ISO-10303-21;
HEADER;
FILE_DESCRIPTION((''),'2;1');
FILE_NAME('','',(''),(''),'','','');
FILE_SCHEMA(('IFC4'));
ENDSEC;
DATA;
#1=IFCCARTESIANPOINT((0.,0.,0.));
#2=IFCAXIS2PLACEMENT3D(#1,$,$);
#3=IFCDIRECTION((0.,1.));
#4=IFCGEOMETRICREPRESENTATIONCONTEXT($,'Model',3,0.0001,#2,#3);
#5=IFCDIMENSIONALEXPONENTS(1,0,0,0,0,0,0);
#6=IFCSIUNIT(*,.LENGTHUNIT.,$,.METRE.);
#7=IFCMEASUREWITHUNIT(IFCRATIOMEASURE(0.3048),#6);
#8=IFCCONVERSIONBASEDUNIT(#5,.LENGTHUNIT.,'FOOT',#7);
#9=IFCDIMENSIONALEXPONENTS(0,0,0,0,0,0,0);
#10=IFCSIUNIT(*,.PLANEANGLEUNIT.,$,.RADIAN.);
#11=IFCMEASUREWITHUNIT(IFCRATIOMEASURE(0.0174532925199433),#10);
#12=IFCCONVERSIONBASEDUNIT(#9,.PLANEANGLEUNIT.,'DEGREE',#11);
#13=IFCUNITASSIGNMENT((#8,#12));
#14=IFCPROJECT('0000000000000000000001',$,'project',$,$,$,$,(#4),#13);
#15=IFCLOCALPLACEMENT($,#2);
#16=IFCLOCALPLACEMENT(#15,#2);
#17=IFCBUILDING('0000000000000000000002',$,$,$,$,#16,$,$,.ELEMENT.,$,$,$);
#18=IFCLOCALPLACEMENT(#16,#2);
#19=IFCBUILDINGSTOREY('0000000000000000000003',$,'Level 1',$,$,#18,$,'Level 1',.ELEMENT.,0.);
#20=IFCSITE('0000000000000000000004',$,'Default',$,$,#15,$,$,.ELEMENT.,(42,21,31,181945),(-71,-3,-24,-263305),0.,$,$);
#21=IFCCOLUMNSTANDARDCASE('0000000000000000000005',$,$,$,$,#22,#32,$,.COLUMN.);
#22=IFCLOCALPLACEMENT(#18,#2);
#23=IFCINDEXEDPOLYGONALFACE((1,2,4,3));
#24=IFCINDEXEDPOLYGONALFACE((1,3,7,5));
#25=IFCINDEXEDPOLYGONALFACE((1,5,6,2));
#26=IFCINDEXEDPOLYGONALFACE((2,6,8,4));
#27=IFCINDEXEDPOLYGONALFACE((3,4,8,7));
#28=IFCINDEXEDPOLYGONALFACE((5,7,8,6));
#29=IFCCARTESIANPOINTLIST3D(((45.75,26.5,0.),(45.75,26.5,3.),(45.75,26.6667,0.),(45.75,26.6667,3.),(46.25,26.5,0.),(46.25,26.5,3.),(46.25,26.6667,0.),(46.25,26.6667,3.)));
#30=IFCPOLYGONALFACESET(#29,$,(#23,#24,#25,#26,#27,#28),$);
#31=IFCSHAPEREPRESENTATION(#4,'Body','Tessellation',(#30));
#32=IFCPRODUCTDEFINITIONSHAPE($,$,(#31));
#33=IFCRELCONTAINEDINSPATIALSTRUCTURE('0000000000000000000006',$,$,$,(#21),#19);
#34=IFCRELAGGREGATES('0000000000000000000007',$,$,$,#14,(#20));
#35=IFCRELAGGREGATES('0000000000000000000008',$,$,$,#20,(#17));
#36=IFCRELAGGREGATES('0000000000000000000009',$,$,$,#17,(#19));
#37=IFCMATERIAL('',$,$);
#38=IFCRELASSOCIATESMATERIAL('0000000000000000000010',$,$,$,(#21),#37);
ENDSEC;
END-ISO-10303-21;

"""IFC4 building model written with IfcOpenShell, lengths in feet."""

from ifc_helpers import new_model, entity, si_unit, converted_unit, direction, frame, origin, place, context, project, spatial, rectangle, extrude, material, element, save


model = new_model("IFC4")

# Units and contexts
model_context = context("Model", 3, precision=0.0001, world=origin(), true_north=direction((0.0, 1.0)))
ifc_project = project(units=[converted_unit("LENGTHUNIT", "FOOT", entity("IfcRatioMeasure", 0.3048), si_unit("LENGTHUNIT", "METRE"), dimensions=[1, 0, 0, 0, 0, 0, 0]), converted_unit("PLANEANGLEUNIT", "DEGREE", entity("IfcRatioMeasure", 0.0174532925199433), si_unit("PLANEANGLEUNIT", "RADIAN"), dimensions=[0, 0, 0, 0, 0, 0, 0])], contexts=[model_context])

# Site, building, storey
site_placement = place(None, origin())
site = spatial("IfcSite", under=ifc_project, at=site_placement, Name="Default", CompositionType="ELEMENT", RefLatitude=(42, 21, 31, 181945), RefLongitude=(-71, -3, -24, -263305), RefElevation=0.0)
building_placement = place(site_placement, origin())
building = spatial("IfcBuilding", under=site, at=building_placement, CompositionType="ELEMENT")
storey_placement = place(building_placement, origin())
storey = spatial("IfcBuildingStorey", under=building, at=storey_placement, Name="Level 1", LongName="Level 1", CompositionType="ELEMENT", Elevation=0.0)

# Column
placement_1 = place(storey_placement, frame((46.0, 46.25, 0.0), z_axis=(0.0, 0.0, 1.0), x_axis=(0.0, -1.0, 0.0)))
ifc_material_1 = material(Name="")
for number, where, z_axis, x_axis in (
    (1, (19.6667, 0.0, 0.0), (0.0, 0.0, 1.0), (1.0, 0.0, 0.0)),
):
    element("IfcColumnStandardCase", number, at=place(placement_1, frame(where, z_axis=z_axis, x_axis=x_axis)), inside=storey, material=ifc_material_1, PredefinedType="COLUMN", context=model_context, shape_type="SweptSolid", body=[
        extrude(rectangle(XDim=0.1667, YDim=0.5), origin(), (0.0, 0.0, 1.0), 3.0),
    ])

save(model, "model.ifc")
